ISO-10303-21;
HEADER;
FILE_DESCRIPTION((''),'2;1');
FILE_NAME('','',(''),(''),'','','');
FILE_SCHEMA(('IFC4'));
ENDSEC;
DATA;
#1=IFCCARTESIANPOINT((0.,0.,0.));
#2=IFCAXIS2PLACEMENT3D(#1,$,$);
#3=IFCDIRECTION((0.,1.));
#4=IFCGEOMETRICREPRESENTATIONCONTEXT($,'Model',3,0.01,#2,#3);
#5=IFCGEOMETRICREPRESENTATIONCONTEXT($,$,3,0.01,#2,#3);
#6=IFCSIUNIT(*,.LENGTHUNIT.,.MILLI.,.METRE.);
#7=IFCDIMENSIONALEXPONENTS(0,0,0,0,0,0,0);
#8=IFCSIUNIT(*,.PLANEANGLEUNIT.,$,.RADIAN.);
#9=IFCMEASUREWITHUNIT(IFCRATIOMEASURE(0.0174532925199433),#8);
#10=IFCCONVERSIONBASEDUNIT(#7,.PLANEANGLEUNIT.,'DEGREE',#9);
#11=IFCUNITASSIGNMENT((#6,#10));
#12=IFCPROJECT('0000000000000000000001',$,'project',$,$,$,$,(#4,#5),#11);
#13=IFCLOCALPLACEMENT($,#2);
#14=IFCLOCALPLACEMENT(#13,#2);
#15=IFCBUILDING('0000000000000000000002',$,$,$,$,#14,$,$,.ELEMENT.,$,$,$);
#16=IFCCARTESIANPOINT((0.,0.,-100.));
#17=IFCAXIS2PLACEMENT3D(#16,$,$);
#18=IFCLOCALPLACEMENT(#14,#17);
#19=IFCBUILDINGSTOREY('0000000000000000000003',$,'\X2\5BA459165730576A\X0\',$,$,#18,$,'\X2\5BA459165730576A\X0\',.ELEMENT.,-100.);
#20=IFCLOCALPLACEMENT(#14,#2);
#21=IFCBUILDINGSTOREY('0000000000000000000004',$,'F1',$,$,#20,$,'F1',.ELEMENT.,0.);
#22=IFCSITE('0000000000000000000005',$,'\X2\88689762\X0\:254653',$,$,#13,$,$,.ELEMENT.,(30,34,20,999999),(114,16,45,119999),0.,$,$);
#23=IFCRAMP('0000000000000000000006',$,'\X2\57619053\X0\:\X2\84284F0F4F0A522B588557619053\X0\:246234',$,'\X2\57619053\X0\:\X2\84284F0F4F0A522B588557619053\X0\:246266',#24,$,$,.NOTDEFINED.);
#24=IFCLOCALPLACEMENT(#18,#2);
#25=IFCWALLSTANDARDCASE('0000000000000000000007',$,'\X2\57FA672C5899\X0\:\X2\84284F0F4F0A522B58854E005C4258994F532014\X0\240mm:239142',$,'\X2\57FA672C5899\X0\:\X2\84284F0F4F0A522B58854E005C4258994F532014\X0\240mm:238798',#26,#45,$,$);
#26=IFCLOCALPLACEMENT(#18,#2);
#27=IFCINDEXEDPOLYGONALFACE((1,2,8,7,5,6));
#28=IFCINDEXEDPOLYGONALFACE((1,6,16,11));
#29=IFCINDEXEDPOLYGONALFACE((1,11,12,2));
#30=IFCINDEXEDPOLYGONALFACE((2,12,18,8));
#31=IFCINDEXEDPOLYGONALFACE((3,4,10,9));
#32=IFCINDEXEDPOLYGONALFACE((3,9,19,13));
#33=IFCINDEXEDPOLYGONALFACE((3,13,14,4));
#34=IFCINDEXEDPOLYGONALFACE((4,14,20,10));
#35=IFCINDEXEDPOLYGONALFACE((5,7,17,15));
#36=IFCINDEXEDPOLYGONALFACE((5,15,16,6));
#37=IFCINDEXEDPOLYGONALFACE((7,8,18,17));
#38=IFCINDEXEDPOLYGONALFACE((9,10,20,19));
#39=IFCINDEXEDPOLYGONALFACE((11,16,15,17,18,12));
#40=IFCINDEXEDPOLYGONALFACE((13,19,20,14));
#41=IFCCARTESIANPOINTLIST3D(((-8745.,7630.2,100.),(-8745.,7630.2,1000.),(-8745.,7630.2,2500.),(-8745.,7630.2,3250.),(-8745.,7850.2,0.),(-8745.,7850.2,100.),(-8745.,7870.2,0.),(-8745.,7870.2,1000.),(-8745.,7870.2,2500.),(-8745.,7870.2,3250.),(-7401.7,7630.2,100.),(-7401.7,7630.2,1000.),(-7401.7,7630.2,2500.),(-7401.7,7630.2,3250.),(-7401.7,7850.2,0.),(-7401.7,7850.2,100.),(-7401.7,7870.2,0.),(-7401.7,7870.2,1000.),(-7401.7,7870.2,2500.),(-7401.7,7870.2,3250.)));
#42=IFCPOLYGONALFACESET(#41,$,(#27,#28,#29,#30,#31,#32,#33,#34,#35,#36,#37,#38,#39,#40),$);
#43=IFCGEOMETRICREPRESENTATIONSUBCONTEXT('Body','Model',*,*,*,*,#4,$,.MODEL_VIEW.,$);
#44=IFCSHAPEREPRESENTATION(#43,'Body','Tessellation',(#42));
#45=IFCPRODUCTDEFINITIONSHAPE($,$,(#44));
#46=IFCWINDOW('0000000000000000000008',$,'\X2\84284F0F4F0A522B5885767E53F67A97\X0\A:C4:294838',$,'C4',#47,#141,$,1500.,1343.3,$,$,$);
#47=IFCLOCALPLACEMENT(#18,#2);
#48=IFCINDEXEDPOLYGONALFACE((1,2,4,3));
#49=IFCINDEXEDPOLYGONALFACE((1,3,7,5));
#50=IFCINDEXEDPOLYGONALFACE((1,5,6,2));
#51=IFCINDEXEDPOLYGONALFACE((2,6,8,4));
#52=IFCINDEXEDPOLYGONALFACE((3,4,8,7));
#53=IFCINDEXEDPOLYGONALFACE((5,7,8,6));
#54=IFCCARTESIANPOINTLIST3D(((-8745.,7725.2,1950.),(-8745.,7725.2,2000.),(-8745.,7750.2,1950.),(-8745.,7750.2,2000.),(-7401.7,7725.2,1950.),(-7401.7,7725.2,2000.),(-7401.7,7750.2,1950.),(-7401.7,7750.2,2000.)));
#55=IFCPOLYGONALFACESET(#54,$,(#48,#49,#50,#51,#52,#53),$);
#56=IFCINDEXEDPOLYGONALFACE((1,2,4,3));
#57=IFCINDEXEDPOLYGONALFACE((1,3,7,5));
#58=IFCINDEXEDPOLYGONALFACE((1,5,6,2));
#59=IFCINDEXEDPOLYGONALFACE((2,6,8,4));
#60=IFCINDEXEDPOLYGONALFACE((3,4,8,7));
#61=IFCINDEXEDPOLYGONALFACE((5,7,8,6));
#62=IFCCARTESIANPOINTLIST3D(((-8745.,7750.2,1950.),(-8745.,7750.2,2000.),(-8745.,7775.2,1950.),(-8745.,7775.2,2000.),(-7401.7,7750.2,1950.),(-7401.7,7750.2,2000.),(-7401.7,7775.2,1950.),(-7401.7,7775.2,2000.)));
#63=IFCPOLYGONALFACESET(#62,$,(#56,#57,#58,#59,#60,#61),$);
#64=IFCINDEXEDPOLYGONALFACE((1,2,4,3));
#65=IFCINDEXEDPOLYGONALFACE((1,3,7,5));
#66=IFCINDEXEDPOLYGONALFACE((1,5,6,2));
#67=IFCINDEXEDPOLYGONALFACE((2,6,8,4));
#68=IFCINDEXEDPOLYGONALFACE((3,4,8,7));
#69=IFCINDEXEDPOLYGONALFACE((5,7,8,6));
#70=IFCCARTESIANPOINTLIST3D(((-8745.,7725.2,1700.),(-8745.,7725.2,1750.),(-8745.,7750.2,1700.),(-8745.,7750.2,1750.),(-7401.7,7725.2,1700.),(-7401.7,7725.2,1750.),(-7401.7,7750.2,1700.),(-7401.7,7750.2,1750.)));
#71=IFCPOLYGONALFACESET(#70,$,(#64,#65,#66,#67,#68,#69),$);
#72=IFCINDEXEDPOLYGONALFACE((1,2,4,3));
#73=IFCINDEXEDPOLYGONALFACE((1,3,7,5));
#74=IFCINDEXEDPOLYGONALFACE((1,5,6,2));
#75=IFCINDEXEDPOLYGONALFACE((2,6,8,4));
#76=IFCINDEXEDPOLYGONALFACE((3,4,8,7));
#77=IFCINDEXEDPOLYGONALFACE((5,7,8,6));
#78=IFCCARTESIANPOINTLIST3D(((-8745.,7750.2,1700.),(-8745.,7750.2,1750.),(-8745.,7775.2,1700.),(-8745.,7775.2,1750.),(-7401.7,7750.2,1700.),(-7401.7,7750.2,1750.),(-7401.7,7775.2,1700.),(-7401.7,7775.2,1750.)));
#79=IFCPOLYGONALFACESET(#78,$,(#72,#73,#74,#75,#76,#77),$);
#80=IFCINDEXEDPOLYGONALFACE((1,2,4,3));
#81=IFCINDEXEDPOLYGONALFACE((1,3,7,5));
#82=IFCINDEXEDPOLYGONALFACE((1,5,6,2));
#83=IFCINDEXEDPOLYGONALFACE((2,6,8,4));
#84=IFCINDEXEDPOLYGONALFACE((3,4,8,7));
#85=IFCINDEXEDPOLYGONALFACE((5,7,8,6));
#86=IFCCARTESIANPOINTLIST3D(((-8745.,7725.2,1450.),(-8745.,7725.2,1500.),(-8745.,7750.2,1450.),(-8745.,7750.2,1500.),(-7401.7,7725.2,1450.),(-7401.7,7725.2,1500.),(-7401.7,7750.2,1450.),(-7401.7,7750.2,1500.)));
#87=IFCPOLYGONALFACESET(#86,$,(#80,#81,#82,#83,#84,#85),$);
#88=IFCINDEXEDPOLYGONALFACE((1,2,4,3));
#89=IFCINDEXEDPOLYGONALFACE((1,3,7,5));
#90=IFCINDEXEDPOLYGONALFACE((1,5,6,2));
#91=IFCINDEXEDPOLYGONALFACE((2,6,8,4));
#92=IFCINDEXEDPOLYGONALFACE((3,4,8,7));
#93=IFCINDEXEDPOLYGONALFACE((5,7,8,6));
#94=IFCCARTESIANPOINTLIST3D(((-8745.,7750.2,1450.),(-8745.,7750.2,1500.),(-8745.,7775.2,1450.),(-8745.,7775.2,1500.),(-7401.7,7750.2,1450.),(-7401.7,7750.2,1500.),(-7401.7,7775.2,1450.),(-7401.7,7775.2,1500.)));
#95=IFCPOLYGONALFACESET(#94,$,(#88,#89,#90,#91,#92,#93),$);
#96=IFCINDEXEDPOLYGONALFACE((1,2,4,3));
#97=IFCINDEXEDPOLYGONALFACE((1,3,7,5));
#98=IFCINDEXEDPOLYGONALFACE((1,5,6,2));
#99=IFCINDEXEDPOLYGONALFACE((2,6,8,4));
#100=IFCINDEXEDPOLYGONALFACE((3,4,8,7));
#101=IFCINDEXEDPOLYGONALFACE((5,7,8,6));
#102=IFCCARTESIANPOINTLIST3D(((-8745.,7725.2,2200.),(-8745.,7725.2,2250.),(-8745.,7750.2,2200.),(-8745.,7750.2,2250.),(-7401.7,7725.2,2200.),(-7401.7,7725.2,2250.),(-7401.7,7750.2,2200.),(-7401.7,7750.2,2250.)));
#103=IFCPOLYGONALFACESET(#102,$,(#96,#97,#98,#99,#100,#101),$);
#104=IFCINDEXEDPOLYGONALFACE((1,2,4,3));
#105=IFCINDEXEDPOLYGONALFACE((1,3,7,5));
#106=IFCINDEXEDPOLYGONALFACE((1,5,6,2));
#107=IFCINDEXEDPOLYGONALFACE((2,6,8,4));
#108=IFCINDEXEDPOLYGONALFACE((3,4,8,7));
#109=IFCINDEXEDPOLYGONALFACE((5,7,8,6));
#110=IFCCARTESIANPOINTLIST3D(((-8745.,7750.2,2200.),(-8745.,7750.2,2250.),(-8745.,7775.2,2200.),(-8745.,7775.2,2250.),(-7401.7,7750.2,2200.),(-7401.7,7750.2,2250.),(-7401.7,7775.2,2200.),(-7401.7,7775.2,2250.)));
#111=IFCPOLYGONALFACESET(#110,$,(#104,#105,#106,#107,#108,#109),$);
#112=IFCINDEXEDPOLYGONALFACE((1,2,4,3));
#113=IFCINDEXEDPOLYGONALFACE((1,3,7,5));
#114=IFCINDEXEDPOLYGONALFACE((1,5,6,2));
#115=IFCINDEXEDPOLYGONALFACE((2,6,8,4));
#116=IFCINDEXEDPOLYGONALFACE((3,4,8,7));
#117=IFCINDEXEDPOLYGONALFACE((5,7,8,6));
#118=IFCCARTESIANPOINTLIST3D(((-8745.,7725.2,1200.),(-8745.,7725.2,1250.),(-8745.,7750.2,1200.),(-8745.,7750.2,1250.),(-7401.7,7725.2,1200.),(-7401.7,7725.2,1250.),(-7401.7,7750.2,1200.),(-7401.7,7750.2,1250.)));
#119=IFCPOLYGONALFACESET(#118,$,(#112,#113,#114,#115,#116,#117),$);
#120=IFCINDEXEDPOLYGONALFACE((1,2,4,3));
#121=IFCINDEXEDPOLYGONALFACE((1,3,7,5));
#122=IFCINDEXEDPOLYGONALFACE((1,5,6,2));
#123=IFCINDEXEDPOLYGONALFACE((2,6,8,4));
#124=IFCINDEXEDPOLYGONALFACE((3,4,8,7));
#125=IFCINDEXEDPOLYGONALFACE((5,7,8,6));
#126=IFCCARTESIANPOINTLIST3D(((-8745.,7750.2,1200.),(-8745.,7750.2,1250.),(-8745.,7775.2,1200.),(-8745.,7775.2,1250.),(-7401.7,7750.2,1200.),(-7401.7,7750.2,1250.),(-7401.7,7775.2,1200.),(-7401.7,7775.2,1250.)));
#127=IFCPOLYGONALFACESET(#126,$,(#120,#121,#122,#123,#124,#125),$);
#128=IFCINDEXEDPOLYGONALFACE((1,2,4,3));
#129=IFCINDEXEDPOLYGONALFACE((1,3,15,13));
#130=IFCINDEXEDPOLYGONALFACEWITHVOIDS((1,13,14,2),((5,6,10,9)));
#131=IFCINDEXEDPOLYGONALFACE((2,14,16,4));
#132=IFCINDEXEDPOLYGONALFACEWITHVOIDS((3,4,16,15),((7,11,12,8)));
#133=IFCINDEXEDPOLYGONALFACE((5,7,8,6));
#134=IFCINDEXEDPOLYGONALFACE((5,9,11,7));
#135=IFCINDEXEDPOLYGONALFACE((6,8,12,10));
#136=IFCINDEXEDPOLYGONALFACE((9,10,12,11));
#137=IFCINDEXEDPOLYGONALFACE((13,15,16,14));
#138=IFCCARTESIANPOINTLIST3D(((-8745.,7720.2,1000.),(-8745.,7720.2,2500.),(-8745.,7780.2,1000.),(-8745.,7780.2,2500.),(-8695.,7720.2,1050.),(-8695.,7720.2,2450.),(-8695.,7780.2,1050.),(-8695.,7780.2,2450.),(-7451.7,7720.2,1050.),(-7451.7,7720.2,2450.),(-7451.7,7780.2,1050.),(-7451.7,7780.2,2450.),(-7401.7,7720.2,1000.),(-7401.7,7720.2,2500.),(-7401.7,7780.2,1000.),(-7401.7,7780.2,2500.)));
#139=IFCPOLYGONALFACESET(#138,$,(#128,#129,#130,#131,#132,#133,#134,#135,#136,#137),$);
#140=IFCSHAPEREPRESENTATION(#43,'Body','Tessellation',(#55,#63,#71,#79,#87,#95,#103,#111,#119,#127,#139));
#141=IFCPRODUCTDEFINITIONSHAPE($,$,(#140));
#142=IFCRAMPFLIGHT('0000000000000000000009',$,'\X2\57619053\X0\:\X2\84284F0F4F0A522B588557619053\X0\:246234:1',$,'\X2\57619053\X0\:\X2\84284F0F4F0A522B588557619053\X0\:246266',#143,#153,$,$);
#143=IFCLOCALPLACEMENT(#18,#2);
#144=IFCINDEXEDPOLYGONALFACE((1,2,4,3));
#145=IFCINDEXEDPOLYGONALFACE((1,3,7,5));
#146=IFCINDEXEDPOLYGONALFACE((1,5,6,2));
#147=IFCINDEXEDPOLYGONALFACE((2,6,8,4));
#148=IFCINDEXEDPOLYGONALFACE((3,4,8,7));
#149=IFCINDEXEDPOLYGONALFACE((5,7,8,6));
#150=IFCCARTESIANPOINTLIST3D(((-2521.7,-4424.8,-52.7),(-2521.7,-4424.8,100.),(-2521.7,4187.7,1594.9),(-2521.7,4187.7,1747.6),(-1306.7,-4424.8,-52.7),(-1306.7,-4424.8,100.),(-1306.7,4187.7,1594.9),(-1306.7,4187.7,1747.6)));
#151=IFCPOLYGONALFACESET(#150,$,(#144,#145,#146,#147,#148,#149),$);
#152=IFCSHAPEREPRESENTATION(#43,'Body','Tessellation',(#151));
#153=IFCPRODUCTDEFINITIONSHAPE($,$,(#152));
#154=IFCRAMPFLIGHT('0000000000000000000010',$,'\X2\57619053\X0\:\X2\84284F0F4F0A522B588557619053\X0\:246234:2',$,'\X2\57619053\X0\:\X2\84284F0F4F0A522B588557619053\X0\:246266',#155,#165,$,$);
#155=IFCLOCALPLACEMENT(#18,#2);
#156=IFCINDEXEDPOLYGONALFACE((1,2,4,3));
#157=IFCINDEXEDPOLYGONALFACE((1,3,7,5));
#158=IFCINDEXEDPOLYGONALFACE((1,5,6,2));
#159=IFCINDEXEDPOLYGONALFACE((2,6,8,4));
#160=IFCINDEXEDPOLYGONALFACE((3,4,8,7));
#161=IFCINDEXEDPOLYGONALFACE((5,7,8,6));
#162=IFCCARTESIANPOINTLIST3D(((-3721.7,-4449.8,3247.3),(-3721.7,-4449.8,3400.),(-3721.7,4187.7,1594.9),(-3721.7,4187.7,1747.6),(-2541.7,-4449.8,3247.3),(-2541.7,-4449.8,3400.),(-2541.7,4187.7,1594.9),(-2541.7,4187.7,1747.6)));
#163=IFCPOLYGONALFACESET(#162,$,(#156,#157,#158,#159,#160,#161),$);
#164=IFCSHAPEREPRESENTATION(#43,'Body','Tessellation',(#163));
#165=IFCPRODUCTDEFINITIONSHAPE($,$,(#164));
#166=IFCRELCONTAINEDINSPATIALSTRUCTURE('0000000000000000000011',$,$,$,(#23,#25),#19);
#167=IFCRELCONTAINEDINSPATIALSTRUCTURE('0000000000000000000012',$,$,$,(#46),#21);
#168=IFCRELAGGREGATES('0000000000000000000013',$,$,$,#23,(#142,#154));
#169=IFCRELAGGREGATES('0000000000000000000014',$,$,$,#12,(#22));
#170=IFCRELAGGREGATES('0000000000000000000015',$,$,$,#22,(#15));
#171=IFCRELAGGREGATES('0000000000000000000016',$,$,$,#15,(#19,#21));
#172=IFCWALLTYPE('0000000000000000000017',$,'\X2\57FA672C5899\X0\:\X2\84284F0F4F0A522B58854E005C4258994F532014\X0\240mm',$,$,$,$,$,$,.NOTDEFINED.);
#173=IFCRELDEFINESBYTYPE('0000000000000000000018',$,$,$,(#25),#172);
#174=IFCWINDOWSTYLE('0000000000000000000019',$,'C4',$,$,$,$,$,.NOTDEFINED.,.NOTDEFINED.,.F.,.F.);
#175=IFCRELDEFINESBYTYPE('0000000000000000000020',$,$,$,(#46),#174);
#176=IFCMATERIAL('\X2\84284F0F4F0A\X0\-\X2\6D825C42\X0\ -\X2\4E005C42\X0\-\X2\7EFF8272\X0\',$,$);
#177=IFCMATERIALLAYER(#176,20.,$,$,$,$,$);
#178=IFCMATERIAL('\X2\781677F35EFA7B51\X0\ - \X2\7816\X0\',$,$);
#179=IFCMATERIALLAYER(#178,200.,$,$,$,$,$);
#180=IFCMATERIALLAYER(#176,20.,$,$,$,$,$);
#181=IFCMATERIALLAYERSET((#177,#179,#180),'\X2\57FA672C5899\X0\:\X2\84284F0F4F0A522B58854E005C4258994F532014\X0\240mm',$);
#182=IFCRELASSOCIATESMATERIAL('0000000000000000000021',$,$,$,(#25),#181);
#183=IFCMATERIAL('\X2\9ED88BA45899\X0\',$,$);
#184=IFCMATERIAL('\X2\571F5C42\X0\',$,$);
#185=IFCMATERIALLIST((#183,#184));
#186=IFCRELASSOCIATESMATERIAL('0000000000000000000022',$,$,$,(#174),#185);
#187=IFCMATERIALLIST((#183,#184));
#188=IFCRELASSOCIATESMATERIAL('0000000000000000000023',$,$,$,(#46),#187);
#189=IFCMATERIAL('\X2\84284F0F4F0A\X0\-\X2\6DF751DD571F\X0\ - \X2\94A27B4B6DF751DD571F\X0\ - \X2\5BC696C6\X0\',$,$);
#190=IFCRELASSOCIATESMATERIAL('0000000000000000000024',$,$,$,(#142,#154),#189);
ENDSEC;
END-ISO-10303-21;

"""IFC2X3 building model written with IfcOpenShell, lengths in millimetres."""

from ifc_helpers import new_model, entity, si_unit, converted_unit, direction, frame, frame_2d, origin, origin_2d_with_axis, place, context, subcontext, project, spatial, polyline, rectangle, outline, extrude, clip, bounded_halfspace, source, transform, mapped, material, material_list, layer, layer_set, layer_usage, type_object, type_shapes, element, fill, aggregate, save


model = new_model("IFC2X3")

# Units and contexts
model_context = context("Model", 3, precision=0.01, world=origin(), true_north=direction((0.0, 1.0)))
context_of_model = context(None, 3, precision=0.01, world=origin(), true_north=direction((0.0, 1.0)))
body_context = subcontext(model_context, "Body", "Model", "MODEL_VIEW")
ifc_project = project(units=[si_unit("LENGTHUNIT", "METRE", prefix="MILLI"), converted_unit("PLANEANGLEUNIT", "DEGREE", entity("IfcRatioMeasure", 0.0174532925199433), si_unit("PLANEANGLEUNIT", "RADIAN"), dimensions=[0, 0, 0, 0, 0, 0, 0])], contexts=[model_context, context_of_model])

# Site, building, storey
site_placement = place(None, origin())
site = spatial("IfcSite", under=ifc_project, at=site_placement, Name="表面:254653", CompositionType="ELEMENT", RefLatitude=(30, 34, 20, 999999), RefLongitude=(114, 16, 45, 119999), RefElevation=0.0)
building_placement = place(site_placement, origin())
building = spatial("IfcBuilding", under=site, at=building_placement, CompositionType="ELEMENT")
storey_1_placement = place(building_placement, frame((0.0, 0.0, -100.0)))
storey_1 = spatial("IfcBuildingStorey", under=building, at=storey_1_placement, Name="室外地坪", LongName="室外地坪", CompositionType="ELEMENT", Elevation=-100.0)

# Ramp
ramp_placement = place(storey_1_placement, origin())
ramp = element("IfcRamp", 1, at=ramp_placement, inside=storey_1, Name="坡道:萨伏伊别墅坡道:246234", ObjectType="坡道:萨伏伊别墅坡道:246266", ShapeType="NOTDEFINED")
ifc_material_1 = material(Name="萨伏伊-混凝土 - 钢筋混凝土 - 密集")

# Wall, opening
ifc_material_2 = material(Name="萨伏伊-涂层 -一层-绿色")
ifc_layer_1 = layer(ifc_material_2, 20.0)
ifc_material_3 = material(Name="砖石建筑 - 砖")
ifc_layer_2 = layer(ifc_material_3, 200.0)
ifc_layer_3 = layer(ifc_material_2, 20.0)
ifc_layer_set = layer_set([ifc_layer_1, ifc_layer_2, ifc_layer_3], Name="基本墙:萨伏伊别墅一层墙体—240mm")
ifc_layer_usage = layer_usage(ifc_layer_set, "AXIS2", "NEGATIVE", 120.0)
wall_type = type_object("IfcWallType", Name="基本墙:萨伏伊别墅一层墙体—240mm", PredefinedType="NOTDEFINED")
wall_placement = place(storey_1_placement, frame((-8745.0, 7750.2, 0.0)))
wall = element("IfcWallStandardCase", 2, at=wall_placement, inside=storey_1, type_object=wall_type, material=ifc_layer_usage, Name="基本墙:萨伏伊别墅一层墙体—240mm:239142", ObjectType="基本墙:萨伏伊别墅一层墙体—240mm:238798", context=body_context, shape_type="Clipping", body=[
    clip(clip(clip(extrude(rectangle(XDim=1343.3, YDim=240.0, at=frame_2d((671.7, 0.0), x_axis=(-1.0, 0.0))), origin(), (0.0, 0.0, 1.0), 3250.0), bounded_halfspace(frame((0.0, -120.0, 3250.0), z_axis=(0.0, 0.0, -1.0), x_axis=(0.0, -1.0, 0.0)), True, frame((0.0, -120.0, 3250.0)), polyline([(0.0, 0.0), (1343.3, 0.0), (1343.3, 240.0), (0.0, 240.0), (0.0, 0.0)]))), bounded_halfspace(frame((0.0, 100.0, 100.0), z_axis=(0.0, 0.0, 1.0), x_axis=(0.0, 1.0, 0.0)), True, frame((0.0, 100.0, 100.0), z_axis=(0.0, 0.0, 1.0), x_axis=(0.0, 1.0, 0.0)), polyline([(0.0, 0.0), (-220.0, 0.0), (-220.0, -1343.3), (0.0, -1343.3), (0.0, 0.0)]))), bounded_halfspace(frame((1343.3, 100.0, 100.0), z_axis=(0.0, 1.0, 0.0), x_axis=(0.0, 0.0, 1.0)), True, frame((1343.3, 100.0, 100.0), z_axis=(0.0, 1.0, 0.0), x_axis=(0.0, 0.0, 1.0)), polyline([(0.0, 0.0), (-100.0, 0.0), (-100.0, -1343.3), (0.0, -1343.3), (0.0, 0.0)]))),
])
opening_placement = place(wall_placement, frame((1343.3, 120.0, 1000.0)))
opening = element("IfcOpeningElement", 3, at=opening_placement, cuts=wall, ObjectType="Opening", context=body_context, shape_type="SweptSolid", body=[
    extrude(rectangle(XDim=1500.0, YDim=1343.3, at=frame_2d((750.0, 671.6), x_axis=(1.0, 0.0))), frame((0.0, 0.0, 0.0), z_axis=(0.0, -1.0, 0.0), x_axis=(0.0, 0.0, 1.0)), (0.0, 0.0, 1.0), 240.0),
])

# Shared definitions
storey_2_placement = place(building_placement, origin())
storey_2 = spatial("IfcBuildingStorey", under=building, at=storey_2_placement, Name="F1", LongName="F1", CompositionType="ELEMENT", Elevation=0.0)

# Window
ifc_material_4 = material(Name="默认墙")
ifc_material_5 = material(Name="土层")
ifc_material_list_1 = material_list([ifc_material_4, ifc_material_5])
ifc_material_list_2 = material_list([ifc_material_4, ifc_material_5])
window_style = type_object("IfcWindowStyle", Name="C4", ConstructionType="NOTDEFINED", OperationType="NOTDEFINED", ParameterTakesPrecedence=False, Sizeable=False, material=ifc_material_list_2)
shared_shape_1 = source(origin(), body_context, "Body", "SweptSolid", [
    extrude(rectangle(XDim=1343.3, YDim=25.0, at=origin_2d_with_axis()), frame((671.6, 132.5, 950.0)), (0.0, 0.0, 1.0), 50.0),
    extrude(rectangle(XDim=1343.3, YDim=25.0, at=origin_2d_with_axis()), frame((671.6, 107.5, 950.0), z_axis=(0.0, 0.0, 1.0), x_axis=(-1.0, 0.0, 0.0)), (0.0, 0.0, 1.0), 50.0),
    extrude(rectangle(XDim=1343.3, YDim=25.0, at=origin_2d_with_axis()), frame((671.6, 132.5, 700.0)), (0.0, 0.0, 1.0), 50.0),
    extrude(rectangle(XDim=1343.3, YDim=25.0, at=origin_2d_with_axis()), frame((671.6, 107.5, 700.0), z_axis=(0.0, 0.0, 1.0), x_axis=(-1.0, 0.0, 0.0)), (0.0, 0.0, 1.0), 50.0),
    extrude(rectangle(XDim=1343.3, YDim=25.0, at=origin_2d_with_axis()), frame((671.6, 132.5, 450.0)), (0.0, 0.0, 1.0), 50.0),
    extrude(rectangle(XDim=1343.3, YDim=25.0, at=origin_2d_with_axis()), frame((671.6, 107.5, 450.0), z_axis=(0.0, 0.0, 1.0), x_axis=(-1.0, 0.0, 0.0)), (0.0, 0.0, 1.0), 50.0),
    extrude(rectangle(XDim=1343.3, YDim=25.0, at=origin_2d_with_axis()), frame((671.6, 132.5, 1200.0)), (0.0, 0.0, 1.0), 50.0),
    extrude(rectangle(XDim=1343.3, YDim=25.0, at=origin_2d_with_axis()), frame((671.6, 107.5, 1200.0), z_axis=(0.0, 0.0, 1.0), x_axis=(-1.0, 0.0, 0.0)), (0.0, 0.0, 1.0), 50.0),
    extrude(rectangle(XDim=1343.3, YDim=25.0, at=origin_2d_with_axis()), frame((671.6, 132.5, 200.0)), (0.0, 0.0, 1.0), 50.0),
    extrude(rectangle(XDim=1343.3, YDim=25.0, at=origin_2d_with_axis()), frame((671.6, 107.5, 200.0), z_axis=(0.0, 0.0, 1.0), x_axis=(-1.0, 0.0, 0.0)), (0.0, 0.0, 1.0), 50.0),
    extrude(outline(polyline([(-671.6, -750.0), (671.6, -750.0), (671.6, 750.0), (-671.6, 750.0), (-671.6, -750.0)]), holes=[polyline([(621.6, -700.0), (-621.6, -700.0), (-621.6, 700.0), (621.6, 700.0), (621.6, -700.0)])]), frame((671.6, 90.0, 750.0), z_axis=(0.0, 1.0, 0.0), x_axis=(1.0, 0.0, 0.0)), (0.0, 0.0, 1.0), 60.0),
])
type_shapes(window_style, [shared_shape_1])
window_placement = place(opening_placement, frame((0.0, 0.0, 0.0), z_axis=(0.0, 0.0, 1.0), x_axis=(-1.0, 0.0, 0.0)))
window = element("IfcWindow", 4, at=window_placement, inside=storey_2, type_object=window_style, material=ifc_material_list_1, Name="萨伏伊别墅百叶窗A:C4:294838", ObjectType="C4", OverallHeight=1500.0, OverallWidth=1343.3, context=body_context, shape_type="MappedRepresentation", body=[
    mapped(shared_shape_1, transform((0.0, 0.0, 0.0), scale=1.0)),
])
fill(opening, window)

# Ramp flights
ramp_flight_1_placement = place(ramp_placement, origin())
ramp_flight_1 = element("IfcRampFlight", 5, at=ramp_flight_1_placement, material=ifc_material_1, Name="坡道:萨伏伊别墅坡道:246234:1", ObjectType="坡道:萨伏伊别墅坡道:246266", context=body_context, shape_type="SweptSolid", body=[
    extrude(outline(polyline([(747.4, -4306.2), (900.2, -4306.2), (-747.4, 4306.2), (-900.2, 4306.2), (747.4, -4306.2)])), frame((-2521.7, -118.6, 847.4), z_axis=(1.0, 0.0, 0.0), x_axis=(0.0, 0.0, -1.0)), (0.0, 0.0, 1.0), 1215.0),
])
ramp_flight_2_placement = place(ramp_placement, origin())
ramp_flight_2 = element("IfcRampFlight", 6, at=ramp_flight_2_placement, material=ifc_material_1, Name="坡道:萨伏伊别墅坡道:246234:2", ObjectType="坡道:萨伏伊别墅坡道:246266", context=body_context, shape_type="SweptSolid", body=[
    extrude(outline(polyline([(-902.6, -4318.7), (-749.8, -4318.7), (902.6, 4318.7), (749.8, 4318.7), (-902.6, -4318.7)])), frame((-3721.7, -131.1, 2497.4), z_axis=(1.0, 0.0, 0.0), x_axis=(0.0, 0.0, -1.0)), (0.0, 0.0, 1.0), 1180.0),
])
aggregate(ramp, [ramp_flight_1, ramp_flight_2])

save(model, "model.ifc")
